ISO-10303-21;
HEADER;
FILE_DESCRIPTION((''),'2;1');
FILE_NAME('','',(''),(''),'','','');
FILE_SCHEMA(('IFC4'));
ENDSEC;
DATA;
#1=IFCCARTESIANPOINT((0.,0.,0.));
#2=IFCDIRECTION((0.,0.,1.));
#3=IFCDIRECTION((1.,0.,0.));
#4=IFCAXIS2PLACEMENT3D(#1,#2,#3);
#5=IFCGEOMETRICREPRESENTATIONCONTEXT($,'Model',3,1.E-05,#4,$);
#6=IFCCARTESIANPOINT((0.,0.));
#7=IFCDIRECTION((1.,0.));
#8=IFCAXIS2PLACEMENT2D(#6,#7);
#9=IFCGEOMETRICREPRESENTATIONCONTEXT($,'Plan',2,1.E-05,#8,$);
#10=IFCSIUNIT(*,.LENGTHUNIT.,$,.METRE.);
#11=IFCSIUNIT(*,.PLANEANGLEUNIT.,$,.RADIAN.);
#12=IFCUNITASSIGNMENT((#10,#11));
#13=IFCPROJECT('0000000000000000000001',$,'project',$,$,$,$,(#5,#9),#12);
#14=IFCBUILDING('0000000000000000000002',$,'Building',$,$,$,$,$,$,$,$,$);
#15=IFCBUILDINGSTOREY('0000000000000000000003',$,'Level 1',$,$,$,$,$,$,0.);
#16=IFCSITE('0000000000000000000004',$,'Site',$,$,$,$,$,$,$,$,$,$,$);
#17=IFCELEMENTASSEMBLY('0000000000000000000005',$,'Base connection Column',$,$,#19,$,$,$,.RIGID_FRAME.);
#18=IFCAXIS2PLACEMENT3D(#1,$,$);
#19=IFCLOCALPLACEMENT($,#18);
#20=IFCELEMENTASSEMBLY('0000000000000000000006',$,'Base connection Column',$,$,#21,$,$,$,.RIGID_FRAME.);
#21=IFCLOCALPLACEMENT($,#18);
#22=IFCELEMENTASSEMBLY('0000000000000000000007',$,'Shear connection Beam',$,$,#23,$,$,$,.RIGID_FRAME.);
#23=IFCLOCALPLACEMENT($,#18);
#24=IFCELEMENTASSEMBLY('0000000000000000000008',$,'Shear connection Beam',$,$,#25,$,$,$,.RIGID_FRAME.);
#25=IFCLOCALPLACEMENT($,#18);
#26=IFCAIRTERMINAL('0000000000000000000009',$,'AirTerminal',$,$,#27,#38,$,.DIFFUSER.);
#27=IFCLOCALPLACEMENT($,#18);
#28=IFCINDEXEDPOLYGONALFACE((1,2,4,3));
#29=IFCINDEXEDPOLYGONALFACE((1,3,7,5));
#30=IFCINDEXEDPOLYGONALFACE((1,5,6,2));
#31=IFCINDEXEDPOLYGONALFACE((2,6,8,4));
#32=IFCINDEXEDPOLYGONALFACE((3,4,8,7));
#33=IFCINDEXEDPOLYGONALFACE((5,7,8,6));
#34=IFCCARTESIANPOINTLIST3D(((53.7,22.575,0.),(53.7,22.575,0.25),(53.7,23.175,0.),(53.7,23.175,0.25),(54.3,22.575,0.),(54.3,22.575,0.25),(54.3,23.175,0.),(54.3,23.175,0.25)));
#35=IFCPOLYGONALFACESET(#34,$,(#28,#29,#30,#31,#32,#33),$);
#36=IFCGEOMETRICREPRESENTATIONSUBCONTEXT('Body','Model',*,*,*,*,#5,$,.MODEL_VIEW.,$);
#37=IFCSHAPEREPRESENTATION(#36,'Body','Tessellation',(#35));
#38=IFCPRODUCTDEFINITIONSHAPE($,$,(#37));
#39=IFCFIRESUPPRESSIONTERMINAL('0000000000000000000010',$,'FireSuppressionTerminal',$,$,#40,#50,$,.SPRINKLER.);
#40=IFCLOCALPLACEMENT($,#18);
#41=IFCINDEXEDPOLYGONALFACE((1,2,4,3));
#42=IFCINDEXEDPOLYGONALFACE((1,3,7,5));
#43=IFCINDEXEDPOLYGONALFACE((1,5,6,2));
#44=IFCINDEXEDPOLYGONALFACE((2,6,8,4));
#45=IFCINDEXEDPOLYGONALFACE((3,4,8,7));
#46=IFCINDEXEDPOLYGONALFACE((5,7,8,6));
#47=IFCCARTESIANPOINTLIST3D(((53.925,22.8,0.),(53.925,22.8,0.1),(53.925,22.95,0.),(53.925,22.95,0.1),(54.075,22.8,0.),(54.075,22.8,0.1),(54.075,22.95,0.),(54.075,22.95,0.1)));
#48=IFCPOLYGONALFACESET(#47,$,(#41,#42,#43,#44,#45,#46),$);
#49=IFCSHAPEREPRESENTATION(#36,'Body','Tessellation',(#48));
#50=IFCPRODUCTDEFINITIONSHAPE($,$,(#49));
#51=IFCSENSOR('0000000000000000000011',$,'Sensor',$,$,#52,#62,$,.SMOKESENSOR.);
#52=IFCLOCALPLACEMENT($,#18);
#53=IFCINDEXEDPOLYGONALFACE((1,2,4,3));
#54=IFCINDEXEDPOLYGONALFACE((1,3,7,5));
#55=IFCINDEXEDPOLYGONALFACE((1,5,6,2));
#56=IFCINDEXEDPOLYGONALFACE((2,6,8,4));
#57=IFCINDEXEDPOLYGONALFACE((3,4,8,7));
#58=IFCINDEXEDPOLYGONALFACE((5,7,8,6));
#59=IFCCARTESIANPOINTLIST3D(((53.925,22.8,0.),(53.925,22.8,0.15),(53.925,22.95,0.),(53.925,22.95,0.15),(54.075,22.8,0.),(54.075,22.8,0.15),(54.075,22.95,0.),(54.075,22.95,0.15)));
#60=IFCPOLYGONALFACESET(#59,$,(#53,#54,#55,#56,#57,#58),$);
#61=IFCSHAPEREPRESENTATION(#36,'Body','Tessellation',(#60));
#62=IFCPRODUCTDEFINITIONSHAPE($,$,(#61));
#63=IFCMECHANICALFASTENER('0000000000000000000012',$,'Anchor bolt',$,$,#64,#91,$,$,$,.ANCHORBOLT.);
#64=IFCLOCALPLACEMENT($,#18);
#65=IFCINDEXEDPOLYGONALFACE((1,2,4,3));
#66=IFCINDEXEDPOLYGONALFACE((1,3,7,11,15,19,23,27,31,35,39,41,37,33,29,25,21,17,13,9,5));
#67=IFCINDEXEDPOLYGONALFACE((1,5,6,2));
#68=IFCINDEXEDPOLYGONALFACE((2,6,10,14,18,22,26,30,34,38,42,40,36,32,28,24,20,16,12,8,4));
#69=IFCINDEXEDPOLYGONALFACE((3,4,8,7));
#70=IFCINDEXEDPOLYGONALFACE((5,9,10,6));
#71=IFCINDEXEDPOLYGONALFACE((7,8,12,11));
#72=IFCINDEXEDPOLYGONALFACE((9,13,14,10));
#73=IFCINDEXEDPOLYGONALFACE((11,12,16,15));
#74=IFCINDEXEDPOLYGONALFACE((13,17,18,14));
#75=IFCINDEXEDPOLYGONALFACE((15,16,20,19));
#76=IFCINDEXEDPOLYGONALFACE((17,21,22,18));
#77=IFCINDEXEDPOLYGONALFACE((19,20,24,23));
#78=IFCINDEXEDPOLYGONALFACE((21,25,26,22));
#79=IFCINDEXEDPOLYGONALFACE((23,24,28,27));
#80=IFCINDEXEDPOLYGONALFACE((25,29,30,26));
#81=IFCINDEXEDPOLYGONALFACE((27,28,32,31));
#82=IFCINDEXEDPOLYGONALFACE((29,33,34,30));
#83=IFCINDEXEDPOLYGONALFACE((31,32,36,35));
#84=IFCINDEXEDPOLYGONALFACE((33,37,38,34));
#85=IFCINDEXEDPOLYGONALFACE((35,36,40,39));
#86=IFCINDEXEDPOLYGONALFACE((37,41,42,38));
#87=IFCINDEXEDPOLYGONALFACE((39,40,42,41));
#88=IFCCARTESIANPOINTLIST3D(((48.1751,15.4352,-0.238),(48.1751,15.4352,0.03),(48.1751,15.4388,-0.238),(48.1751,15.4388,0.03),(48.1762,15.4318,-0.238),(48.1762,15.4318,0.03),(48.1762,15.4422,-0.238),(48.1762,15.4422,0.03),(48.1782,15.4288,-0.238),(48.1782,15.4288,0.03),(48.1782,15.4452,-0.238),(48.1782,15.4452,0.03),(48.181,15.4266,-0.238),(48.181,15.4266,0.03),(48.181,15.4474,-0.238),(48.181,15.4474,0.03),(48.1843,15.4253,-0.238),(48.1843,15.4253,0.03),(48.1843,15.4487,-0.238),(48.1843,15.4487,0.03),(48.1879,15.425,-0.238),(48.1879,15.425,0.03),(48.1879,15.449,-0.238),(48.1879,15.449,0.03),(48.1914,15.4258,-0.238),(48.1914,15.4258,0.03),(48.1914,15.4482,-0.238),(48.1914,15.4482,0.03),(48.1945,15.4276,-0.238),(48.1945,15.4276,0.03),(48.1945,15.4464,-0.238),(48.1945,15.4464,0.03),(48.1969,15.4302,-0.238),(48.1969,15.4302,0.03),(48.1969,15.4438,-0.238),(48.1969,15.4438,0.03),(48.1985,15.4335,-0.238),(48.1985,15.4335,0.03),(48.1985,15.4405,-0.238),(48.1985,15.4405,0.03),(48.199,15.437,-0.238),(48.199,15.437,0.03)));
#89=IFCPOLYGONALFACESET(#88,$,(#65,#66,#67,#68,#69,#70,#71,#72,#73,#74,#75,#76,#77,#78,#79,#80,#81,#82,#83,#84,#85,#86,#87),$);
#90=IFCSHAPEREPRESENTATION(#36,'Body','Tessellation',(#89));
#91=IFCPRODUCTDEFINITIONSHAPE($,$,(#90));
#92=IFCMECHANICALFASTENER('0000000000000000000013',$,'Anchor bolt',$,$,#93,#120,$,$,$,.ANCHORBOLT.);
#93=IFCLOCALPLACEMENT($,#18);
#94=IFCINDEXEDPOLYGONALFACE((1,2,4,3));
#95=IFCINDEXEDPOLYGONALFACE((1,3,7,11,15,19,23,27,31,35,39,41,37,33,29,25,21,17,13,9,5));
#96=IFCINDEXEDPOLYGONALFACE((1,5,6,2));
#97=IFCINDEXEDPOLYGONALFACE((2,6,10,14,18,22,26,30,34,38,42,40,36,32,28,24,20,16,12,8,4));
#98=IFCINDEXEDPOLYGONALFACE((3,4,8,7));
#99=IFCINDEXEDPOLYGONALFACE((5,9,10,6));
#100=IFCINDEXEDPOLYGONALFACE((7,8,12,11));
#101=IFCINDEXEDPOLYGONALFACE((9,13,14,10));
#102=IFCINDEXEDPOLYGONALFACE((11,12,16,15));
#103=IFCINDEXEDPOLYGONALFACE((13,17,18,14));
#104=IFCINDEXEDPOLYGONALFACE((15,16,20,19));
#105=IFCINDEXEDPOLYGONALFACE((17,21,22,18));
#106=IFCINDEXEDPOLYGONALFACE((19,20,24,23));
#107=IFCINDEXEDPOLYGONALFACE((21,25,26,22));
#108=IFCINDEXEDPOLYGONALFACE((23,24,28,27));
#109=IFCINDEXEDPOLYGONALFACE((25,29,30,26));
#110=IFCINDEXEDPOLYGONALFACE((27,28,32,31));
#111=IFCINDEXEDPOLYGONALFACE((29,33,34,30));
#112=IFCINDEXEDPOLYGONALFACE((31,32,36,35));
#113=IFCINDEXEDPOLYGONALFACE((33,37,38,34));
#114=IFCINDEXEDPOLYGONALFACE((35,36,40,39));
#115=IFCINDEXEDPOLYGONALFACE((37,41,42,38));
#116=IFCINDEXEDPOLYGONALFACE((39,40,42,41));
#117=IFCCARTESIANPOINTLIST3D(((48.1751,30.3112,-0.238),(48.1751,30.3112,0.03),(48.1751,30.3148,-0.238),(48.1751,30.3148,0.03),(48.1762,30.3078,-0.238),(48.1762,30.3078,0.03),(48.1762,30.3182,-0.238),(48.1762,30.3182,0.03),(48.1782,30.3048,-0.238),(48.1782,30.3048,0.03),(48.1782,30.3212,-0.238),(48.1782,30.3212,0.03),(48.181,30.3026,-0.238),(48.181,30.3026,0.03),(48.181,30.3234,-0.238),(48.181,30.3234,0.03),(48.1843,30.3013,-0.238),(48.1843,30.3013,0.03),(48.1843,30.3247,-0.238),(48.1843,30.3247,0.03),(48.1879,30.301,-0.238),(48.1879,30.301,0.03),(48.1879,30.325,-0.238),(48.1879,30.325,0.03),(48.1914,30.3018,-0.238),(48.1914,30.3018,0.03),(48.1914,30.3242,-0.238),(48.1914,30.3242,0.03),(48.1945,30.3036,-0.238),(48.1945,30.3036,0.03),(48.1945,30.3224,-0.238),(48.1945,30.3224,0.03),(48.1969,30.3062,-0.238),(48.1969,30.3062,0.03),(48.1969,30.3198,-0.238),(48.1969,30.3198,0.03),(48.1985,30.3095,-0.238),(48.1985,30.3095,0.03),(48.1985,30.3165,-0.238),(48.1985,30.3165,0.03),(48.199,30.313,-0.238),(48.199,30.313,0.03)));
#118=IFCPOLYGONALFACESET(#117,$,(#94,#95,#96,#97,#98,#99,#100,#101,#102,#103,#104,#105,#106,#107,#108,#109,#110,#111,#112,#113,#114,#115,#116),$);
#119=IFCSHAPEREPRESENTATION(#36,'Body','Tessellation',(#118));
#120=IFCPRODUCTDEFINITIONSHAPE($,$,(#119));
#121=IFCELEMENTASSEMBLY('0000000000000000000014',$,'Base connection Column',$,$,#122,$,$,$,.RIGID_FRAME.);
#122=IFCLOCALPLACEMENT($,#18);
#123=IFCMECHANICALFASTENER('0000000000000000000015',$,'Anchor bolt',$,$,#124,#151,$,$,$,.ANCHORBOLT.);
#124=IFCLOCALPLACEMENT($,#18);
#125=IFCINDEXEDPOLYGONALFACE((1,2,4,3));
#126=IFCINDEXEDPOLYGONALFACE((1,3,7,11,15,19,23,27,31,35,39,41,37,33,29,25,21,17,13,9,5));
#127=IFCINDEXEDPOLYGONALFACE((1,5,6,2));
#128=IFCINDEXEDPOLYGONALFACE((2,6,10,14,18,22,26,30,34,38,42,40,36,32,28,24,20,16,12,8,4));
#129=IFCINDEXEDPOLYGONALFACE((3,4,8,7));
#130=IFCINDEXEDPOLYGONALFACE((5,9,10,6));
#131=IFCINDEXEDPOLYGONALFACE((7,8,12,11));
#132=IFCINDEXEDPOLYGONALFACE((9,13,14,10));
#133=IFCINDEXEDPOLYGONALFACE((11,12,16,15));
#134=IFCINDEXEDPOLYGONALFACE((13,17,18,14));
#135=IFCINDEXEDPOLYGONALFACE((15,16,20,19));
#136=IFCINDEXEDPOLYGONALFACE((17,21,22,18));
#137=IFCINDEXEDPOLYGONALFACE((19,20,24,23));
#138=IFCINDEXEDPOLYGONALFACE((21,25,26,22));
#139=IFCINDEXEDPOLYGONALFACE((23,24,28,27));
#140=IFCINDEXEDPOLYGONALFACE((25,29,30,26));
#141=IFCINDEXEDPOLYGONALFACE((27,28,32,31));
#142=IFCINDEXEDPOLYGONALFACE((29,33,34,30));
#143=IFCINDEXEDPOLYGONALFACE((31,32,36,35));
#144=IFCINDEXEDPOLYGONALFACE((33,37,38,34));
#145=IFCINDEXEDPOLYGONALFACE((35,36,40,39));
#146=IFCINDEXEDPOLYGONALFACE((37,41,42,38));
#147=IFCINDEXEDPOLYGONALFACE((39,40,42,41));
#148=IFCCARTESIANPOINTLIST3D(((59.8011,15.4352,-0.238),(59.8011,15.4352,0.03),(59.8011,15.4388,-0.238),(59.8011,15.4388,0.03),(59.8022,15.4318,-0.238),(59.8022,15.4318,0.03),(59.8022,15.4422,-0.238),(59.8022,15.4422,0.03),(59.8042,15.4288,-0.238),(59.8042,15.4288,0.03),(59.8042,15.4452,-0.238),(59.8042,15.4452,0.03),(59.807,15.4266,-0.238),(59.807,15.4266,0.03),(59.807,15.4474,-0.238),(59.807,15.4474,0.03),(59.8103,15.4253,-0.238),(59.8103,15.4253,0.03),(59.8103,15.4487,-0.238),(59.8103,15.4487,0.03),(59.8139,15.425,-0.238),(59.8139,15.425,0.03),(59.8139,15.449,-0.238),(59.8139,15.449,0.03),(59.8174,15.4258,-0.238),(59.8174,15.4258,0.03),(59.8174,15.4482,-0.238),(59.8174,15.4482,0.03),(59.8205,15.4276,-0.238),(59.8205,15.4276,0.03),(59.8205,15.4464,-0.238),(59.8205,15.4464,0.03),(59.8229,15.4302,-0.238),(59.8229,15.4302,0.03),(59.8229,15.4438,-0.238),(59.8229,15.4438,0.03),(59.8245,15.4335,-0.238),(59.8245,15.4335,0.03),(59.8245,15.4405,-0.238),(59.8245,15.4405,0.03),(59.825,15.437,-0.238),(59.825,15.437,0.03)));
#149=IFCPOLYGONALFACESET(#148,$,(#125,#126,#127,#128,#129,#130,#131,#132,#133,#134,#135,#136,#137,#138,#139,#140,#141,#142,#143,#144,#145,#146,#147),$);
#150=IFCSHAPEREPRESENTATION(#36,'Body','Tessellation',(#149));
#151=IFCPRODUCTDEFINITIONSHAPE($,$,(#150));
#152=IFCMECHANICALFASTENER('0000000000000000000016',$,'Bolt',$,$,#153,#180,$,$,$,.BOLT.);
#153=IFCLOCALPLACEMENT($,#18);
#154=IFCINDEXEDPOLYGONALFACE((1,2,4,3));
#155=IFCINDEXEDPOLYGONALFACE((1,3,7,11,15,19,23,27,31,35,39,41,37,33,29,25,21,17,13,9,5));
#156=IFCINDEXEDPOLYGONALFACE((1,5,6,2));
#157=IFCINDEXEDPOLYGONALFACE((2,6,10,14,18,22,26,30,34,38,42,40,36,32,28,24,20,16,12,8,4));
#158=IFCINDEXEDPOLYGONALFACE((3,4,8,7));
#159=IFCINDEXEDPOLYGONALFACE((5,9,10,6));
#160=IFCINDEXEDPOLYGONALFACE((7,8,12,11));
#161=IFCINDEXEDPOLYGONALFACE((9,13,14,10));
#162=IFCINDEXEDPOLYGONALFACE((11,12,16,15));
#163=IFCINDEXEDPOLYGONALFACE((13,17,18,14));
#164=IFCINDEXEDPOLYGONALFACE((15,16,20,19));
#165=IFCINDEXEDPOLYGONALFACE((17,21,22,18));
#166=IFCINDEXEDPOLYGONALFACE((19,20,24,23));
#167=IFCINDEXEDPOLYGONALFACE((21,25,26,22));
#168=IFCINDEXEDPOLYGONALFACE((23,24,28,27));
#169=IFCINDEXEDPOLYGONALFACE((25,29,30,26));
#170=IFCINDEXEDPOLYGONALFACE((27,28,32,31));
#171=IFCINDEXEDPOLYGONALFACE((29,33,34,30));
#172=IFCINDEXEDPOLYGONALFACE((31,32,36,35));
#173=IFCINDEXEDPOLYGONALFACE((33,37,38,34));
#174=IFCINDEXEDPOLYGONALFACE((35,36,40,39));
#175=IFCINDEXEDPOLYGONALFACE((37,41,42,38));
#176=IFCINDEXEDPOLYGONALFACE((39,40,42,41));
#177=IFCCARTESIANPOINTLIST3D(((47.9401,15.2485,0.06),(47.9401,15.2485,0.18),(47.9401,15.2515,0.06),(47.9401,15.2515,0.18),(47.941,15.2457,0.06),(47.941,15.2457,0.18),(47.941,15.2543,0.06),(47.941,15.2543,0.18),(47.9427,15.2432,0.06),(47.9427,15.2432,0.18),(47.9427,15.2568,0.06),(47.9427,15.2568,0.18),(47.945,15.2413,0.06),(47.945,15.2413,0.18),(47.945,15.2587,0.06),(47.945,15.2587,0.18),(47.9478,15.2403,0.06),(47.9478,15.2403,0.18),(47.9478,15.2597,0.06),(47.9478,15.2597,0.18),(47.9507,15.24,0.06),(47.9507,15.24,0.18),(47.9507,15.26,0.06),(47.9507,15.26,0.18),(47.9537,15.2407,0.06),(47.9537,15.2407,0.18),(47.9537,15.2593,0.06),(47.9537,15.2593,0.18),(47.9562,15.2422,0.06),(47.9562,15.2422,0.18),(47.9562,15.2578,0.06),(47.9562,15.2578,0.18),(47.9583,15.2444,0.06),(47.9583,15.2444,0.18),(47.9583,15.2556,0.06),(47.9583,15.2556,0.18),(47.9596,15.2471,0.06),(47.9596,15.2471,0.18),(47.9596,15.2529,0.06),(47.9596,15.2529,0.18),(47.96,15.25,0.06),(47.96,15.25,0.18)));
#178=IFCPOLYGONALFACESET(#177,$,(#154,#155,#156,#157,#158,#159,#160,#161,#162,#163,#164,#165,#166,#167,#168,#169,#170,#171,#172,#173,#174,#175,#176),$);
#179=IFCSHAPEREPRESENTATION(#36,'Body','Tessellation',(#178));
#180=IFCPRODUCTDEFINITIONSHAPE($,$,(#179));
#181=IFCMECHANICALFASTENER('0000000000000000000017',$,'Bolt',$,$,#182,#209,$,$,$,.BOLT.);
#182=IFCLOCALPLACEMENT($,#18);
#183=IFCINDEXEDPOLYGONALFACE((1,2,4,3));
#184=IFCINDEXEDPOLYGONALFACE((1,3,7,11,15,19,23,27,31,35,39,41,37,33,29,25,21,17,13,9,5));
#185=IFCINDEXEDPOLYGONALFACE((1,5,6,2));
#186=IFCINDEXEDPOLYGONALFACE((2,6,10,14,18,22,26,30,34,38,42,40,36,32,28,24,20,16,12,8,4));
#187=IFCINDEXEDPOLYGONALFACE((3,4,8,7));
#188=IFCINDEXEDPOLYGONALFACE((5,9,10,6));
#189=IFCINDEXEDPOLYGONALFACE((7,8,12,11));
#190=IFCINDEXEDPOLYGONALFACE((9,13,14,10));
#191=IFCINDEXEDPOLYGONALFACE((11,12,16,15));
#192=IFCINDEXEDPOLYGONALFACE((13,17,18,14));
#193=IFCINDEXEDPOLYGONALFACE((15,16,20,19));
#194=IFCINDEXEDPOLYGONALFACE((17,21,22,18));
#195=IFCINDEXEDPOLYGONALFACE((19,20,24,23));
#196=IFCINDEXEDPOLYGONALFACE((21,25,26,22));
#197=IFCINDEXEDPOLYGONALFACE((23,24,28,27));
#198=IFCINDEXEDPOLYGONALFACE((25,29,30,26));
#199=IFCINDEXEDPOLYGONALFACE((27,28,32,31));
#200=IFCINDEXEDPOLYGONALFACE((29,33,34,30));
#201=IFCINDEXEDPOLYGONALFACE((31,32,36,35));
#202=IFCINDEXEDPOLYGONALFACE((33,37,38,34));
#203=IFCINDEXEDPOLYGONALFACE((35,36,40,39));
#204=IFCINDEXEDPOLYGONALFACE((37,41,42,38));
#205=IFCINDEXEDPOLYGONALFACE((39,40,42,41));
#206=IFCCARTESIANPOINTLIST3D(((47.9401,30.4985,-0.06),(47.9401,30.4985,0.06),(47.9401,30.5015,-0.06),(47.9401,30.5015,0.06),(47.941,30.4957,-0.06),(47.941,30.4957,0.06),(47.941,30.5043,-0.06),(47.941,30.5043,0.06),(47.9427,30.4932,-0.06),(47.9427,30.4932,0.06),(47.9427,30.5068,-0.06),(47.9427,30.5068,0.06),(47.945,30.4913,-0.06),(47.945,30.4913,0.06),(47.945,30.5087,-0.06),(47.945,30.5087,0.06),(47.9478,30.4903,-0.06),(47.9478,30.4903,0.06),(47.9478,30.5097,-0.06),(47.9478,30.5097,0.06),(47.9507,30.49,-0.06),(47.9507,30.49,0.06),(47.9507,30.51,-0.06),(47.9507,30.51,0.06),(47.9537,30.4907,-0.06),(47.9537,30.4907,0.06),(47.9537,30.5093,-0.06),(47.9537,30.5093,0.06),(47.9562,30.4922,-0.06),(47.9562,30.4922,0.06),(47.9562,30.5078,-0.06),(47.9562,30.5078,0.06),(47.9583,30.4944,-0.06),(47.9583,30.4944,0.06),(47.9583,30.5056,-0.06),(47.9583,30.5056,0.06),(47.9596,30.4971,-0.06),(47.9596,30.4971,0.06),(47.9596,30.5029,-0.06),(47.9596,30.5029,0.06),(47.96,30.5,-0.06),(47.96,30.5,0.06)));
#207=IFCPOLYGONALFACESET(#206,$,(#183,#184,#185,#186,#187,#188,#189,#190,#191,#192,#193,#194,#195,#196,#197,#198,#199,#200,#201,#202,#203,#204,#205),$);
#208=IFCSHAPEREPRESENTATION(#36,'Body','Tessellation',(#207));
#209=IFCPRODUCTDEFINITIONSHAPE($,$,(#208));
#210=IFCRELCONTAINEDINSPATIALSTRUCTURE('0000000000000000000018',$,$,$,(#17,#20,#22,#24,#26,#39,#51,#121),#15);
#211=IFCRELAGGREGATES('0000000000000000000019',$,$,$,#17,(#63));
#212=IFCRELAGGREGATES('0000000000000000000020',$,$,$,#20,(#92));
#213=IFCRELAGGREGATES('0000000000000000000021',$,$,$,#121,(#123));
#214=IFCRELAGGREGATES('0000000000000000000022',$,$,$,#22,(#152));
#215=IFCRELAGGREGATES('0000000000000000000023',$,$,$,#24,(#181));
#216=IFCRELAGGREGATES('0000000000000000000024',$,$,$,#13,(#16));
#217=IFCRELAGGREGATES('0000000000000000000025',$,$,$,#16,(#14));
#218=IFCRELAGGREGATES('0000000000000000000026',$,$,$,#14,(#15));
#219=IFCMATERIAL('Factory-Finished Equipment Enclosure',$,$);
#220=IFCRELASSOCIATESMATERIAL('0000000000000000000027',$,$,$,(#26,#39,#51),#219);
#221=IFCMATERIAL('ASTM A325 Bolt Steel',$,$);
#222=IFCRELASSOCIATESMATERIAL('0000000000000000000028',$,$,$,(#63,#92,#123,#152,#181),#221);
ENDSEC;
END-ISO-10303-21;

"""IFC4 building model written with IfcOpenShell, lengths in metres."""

from ifc_helpers import new_model, si_unit, frame, origin_with_axes, origin_2d, origin_2d_with_axis, place, context, subcontext, project, spatial, rectangle, circle, extrude, material, element, aggregate, save


model = new_model("IFC4")

# Units and contexts
model_context = context("Model", 3, precision=1e-05, world=origin_with_axes())
plan_context = context("Plan", 2, precision=1e-05, world=origin_2d_with_axis())
body_context = subcontext(model_context, "Body", "Model", "MODEL_VIEW")
ifc_project = project(units=[si_unit("LENGTHUNIT", "METRE"), si_unit("PLANEANGLEUNIT", "RADIAN")], contexts=[model_context, plan_context])

# Site, building, storey
site = spatial("IfcSite", under=ifc_project, Name="Site")
building = spatial("IfcBuilding", under=site, Name="Building")
storey = spatial("IfcBuildingStorey", under=building, Name="Level 1", Elevation=0.0)

# Element assemblies
assembly_1 = element("IfcElementAssembly", 1, inside=storey, Name="Base connection Column", PredefinedType="RIGID_FRAME")
assembly_2 = element("IfcElementAssembly", 2, inside=storey, Name="Base connection Column", PredefinedType="RIGID_FRAME")

# Element assemblies
assembly_3 = element("IfcElementAssembly", 3, inside=storey, Name="Shear connection Beam", PredefinedType="RIGID_FRAME")
assembly_4 = element("IfcElementAssembly", 4, inside=storey, Name="Shear connection Beam", PredefinedType="RIGID_FRAME")

# Air terminal
ifc_material_1 = material(Name="Factory-Finished Equipment Enclosure")
air_terminal_placement = place(None, frame((54.0, 22.875, 0.0), z_axis=(0.0, 0.0, 1.0), x_axis=(1.0, 0.0, 0.0)))
element("IfcAirTerminal", 5, at=air_terminal_placement, inside=storey, material=ifc_material_1, Name="AirTerminal", PredefinedType="DIFFUSER", context=body_context, shape_type="SweptSolid", body=[
    extrude(rectangle(XDim=0.6, YDim=0.6, at=origin_2d_with_axis()), origin_with_axes(), (0.0, 0.0, 1.0), 0.25),
])

# Fire suppression terminal
fire_suppression_terminal_placement = place(None, frame((54.0, 22.875, 0.0), z_axis=(0.0, 0.0, 1.0), x_axis=(1.0, 0.0, 0.0)))
element("IfcFireSuppressionTerminal", 6, at=fire_suppression_terminal_placement, inside=storey, material=ifc_material_1, Name="FireSuppressionTerminal", PredefinedType="SPRINKLER", context=body_context, shape_type="SweptSolid", body=[
    extrude(rectangle(XDim=0.15, YDim=0.15, at=origin_2d_with_axis()), origin_with_axes(), (0.0, 0.0, 1.0), 0.1),
])

# Sensor
sensor_placement = place(None, frame((54.0, 22.875, 0.0), z_axis=(0.0, 0.0, 1.0), x_axis=(1.0, 0.0, 0.0)))
element("IfcSensor", 7, at=sensor_placement, inside=storey, material=ifc_material_1, Name="Sensor", PredefinedType="SMOKESENSOR", context=body_context, shape_type="SweptSolid", body=[
    extrude(rectangle(XDim=0.15, YDim=0.15, at=origin_2d_with_axis()), origin_with_axes(), (0.0, 0.0, 1.0), 0.15),
])

# Mechanical fasteners
ifc_material_2 = material(Name="ASTM A325 Bolt Steel")
mechanical_fastener_1_placement = place(None, frame((48.187, 15.437, -0.238), z_axis=(0.0, 0.0, 1.0), x_axis=(1.0, 0.0, 0.0)))
mechanical_fastener_1 = element("IfcMechanicalFastener", 8, at=mechanical_fastener_1_placement, material=ifc_material_2, Name="Anchor bolt", PredefinedType="ANCHORBOLT", context=body_context, shape_type="SweptSolid", body=[
    extrude(circle(Radius=0.012, at=origin_2d()), origin_with_axes(), (0.0, 0.0, 1.0), 0.268),
])
aggregate(assembly_1, [mechanical_fastener_1])
mechanical_fastener_2_placement = place(None, frame((48.187, 30.313, -0.238), z_axis=(0.0, 0.0, 1.0), x_axis=(1.0, 0.0, 0.0)))
mechanical_fastener_2 = element("IfcMechanicalFastener", 9, at=mechanical_fastener_2_placement, material=ifc_material_2, Name="Anchor bolt", PredefinedType="ANCHORBOLT", context=body_context, shape_type="SweptSolid", body=[
    extrude(circle(Radius=0.012, at=origin_2d()), origin_with_axes(), (0.0, 0.0, 1.0), 0.268),
])
aggregate(assembly_2, [mechanical_fastener_2])

# Element assembly, mechanical fastener
assembly_5 = element("IfcElementAssembly", 10, inside=storey, Name="Base connection Column", PredefinedType="RIGID_FRAME")
mechanical_fastener_3_placement = place(None, frame((59.813, 15.437, -0.238), z_axis=(0.0, 0.0, 1.0), x_axis=(1.0, 0.0, 0.0)))
mechanical_fastener_3 = element("IfcMechanicalFastener", 11, at=mechanical_fastener_3_placement, material=ifc_material_2, Name="Anchor bolt", PredefinedType="ANCHORBOLT", context=body_context, shape_type="SweptSolid", body=[
    extrude(circle(Radius=0.012, at=origin_2d()), origin_with_axes(), (0.0, 0.0, 1.0), 0.268),
])
aggregate(assembly_5, [mechanical_fastener_3])

# Mechanical fasteners
mechanical_fastener_4_placement = place(None, frame((47.95, 15.25, 0.06), z_axis=(0.0, 0.0, 1.0), x_axis=(1.0, 0.0, 0.0)))
mechanical_fastener_4 = element("IfcMechanicalFastener", 12, at=mechanical_fastener_4_placement, material=ifc_material_2, Name="Bolt", PredefinedType="BOLT", context=body_context, shape_type="SweptSolid", body=[
    extrude(circle(Radius=0.01, at=origin_2d()), origin_with_axes(), (0.0, 0.0, 1.0), 0.12),
])
aggregate(assembly_3, [mechanical_fastener_4])
mechanical_fastener_5_placement = place(None, frame((47.95, 30.5, -0.06), z_axis=(0.0, 0.0, 1.0), x_axis=(1.0, 0.0, 0.0)))
mechanical_fastener_5 = element("IfcMechanicalFastener", 13, at=mechanical_fastener_5_placement, material=ifc_material_2, Name="Bolt", PredefinedType="BOLT", context=body_context, shape_type="SweptSolid", body=[
    extrude(circle(Radius=0.01, at=origin_2d()), origin_with_axes(), (0.0, 0.0, 1.0), 0.12),
])
aggregate(assembly_4, [mechanical_fastener_5])

save(model, "model.ifc")
